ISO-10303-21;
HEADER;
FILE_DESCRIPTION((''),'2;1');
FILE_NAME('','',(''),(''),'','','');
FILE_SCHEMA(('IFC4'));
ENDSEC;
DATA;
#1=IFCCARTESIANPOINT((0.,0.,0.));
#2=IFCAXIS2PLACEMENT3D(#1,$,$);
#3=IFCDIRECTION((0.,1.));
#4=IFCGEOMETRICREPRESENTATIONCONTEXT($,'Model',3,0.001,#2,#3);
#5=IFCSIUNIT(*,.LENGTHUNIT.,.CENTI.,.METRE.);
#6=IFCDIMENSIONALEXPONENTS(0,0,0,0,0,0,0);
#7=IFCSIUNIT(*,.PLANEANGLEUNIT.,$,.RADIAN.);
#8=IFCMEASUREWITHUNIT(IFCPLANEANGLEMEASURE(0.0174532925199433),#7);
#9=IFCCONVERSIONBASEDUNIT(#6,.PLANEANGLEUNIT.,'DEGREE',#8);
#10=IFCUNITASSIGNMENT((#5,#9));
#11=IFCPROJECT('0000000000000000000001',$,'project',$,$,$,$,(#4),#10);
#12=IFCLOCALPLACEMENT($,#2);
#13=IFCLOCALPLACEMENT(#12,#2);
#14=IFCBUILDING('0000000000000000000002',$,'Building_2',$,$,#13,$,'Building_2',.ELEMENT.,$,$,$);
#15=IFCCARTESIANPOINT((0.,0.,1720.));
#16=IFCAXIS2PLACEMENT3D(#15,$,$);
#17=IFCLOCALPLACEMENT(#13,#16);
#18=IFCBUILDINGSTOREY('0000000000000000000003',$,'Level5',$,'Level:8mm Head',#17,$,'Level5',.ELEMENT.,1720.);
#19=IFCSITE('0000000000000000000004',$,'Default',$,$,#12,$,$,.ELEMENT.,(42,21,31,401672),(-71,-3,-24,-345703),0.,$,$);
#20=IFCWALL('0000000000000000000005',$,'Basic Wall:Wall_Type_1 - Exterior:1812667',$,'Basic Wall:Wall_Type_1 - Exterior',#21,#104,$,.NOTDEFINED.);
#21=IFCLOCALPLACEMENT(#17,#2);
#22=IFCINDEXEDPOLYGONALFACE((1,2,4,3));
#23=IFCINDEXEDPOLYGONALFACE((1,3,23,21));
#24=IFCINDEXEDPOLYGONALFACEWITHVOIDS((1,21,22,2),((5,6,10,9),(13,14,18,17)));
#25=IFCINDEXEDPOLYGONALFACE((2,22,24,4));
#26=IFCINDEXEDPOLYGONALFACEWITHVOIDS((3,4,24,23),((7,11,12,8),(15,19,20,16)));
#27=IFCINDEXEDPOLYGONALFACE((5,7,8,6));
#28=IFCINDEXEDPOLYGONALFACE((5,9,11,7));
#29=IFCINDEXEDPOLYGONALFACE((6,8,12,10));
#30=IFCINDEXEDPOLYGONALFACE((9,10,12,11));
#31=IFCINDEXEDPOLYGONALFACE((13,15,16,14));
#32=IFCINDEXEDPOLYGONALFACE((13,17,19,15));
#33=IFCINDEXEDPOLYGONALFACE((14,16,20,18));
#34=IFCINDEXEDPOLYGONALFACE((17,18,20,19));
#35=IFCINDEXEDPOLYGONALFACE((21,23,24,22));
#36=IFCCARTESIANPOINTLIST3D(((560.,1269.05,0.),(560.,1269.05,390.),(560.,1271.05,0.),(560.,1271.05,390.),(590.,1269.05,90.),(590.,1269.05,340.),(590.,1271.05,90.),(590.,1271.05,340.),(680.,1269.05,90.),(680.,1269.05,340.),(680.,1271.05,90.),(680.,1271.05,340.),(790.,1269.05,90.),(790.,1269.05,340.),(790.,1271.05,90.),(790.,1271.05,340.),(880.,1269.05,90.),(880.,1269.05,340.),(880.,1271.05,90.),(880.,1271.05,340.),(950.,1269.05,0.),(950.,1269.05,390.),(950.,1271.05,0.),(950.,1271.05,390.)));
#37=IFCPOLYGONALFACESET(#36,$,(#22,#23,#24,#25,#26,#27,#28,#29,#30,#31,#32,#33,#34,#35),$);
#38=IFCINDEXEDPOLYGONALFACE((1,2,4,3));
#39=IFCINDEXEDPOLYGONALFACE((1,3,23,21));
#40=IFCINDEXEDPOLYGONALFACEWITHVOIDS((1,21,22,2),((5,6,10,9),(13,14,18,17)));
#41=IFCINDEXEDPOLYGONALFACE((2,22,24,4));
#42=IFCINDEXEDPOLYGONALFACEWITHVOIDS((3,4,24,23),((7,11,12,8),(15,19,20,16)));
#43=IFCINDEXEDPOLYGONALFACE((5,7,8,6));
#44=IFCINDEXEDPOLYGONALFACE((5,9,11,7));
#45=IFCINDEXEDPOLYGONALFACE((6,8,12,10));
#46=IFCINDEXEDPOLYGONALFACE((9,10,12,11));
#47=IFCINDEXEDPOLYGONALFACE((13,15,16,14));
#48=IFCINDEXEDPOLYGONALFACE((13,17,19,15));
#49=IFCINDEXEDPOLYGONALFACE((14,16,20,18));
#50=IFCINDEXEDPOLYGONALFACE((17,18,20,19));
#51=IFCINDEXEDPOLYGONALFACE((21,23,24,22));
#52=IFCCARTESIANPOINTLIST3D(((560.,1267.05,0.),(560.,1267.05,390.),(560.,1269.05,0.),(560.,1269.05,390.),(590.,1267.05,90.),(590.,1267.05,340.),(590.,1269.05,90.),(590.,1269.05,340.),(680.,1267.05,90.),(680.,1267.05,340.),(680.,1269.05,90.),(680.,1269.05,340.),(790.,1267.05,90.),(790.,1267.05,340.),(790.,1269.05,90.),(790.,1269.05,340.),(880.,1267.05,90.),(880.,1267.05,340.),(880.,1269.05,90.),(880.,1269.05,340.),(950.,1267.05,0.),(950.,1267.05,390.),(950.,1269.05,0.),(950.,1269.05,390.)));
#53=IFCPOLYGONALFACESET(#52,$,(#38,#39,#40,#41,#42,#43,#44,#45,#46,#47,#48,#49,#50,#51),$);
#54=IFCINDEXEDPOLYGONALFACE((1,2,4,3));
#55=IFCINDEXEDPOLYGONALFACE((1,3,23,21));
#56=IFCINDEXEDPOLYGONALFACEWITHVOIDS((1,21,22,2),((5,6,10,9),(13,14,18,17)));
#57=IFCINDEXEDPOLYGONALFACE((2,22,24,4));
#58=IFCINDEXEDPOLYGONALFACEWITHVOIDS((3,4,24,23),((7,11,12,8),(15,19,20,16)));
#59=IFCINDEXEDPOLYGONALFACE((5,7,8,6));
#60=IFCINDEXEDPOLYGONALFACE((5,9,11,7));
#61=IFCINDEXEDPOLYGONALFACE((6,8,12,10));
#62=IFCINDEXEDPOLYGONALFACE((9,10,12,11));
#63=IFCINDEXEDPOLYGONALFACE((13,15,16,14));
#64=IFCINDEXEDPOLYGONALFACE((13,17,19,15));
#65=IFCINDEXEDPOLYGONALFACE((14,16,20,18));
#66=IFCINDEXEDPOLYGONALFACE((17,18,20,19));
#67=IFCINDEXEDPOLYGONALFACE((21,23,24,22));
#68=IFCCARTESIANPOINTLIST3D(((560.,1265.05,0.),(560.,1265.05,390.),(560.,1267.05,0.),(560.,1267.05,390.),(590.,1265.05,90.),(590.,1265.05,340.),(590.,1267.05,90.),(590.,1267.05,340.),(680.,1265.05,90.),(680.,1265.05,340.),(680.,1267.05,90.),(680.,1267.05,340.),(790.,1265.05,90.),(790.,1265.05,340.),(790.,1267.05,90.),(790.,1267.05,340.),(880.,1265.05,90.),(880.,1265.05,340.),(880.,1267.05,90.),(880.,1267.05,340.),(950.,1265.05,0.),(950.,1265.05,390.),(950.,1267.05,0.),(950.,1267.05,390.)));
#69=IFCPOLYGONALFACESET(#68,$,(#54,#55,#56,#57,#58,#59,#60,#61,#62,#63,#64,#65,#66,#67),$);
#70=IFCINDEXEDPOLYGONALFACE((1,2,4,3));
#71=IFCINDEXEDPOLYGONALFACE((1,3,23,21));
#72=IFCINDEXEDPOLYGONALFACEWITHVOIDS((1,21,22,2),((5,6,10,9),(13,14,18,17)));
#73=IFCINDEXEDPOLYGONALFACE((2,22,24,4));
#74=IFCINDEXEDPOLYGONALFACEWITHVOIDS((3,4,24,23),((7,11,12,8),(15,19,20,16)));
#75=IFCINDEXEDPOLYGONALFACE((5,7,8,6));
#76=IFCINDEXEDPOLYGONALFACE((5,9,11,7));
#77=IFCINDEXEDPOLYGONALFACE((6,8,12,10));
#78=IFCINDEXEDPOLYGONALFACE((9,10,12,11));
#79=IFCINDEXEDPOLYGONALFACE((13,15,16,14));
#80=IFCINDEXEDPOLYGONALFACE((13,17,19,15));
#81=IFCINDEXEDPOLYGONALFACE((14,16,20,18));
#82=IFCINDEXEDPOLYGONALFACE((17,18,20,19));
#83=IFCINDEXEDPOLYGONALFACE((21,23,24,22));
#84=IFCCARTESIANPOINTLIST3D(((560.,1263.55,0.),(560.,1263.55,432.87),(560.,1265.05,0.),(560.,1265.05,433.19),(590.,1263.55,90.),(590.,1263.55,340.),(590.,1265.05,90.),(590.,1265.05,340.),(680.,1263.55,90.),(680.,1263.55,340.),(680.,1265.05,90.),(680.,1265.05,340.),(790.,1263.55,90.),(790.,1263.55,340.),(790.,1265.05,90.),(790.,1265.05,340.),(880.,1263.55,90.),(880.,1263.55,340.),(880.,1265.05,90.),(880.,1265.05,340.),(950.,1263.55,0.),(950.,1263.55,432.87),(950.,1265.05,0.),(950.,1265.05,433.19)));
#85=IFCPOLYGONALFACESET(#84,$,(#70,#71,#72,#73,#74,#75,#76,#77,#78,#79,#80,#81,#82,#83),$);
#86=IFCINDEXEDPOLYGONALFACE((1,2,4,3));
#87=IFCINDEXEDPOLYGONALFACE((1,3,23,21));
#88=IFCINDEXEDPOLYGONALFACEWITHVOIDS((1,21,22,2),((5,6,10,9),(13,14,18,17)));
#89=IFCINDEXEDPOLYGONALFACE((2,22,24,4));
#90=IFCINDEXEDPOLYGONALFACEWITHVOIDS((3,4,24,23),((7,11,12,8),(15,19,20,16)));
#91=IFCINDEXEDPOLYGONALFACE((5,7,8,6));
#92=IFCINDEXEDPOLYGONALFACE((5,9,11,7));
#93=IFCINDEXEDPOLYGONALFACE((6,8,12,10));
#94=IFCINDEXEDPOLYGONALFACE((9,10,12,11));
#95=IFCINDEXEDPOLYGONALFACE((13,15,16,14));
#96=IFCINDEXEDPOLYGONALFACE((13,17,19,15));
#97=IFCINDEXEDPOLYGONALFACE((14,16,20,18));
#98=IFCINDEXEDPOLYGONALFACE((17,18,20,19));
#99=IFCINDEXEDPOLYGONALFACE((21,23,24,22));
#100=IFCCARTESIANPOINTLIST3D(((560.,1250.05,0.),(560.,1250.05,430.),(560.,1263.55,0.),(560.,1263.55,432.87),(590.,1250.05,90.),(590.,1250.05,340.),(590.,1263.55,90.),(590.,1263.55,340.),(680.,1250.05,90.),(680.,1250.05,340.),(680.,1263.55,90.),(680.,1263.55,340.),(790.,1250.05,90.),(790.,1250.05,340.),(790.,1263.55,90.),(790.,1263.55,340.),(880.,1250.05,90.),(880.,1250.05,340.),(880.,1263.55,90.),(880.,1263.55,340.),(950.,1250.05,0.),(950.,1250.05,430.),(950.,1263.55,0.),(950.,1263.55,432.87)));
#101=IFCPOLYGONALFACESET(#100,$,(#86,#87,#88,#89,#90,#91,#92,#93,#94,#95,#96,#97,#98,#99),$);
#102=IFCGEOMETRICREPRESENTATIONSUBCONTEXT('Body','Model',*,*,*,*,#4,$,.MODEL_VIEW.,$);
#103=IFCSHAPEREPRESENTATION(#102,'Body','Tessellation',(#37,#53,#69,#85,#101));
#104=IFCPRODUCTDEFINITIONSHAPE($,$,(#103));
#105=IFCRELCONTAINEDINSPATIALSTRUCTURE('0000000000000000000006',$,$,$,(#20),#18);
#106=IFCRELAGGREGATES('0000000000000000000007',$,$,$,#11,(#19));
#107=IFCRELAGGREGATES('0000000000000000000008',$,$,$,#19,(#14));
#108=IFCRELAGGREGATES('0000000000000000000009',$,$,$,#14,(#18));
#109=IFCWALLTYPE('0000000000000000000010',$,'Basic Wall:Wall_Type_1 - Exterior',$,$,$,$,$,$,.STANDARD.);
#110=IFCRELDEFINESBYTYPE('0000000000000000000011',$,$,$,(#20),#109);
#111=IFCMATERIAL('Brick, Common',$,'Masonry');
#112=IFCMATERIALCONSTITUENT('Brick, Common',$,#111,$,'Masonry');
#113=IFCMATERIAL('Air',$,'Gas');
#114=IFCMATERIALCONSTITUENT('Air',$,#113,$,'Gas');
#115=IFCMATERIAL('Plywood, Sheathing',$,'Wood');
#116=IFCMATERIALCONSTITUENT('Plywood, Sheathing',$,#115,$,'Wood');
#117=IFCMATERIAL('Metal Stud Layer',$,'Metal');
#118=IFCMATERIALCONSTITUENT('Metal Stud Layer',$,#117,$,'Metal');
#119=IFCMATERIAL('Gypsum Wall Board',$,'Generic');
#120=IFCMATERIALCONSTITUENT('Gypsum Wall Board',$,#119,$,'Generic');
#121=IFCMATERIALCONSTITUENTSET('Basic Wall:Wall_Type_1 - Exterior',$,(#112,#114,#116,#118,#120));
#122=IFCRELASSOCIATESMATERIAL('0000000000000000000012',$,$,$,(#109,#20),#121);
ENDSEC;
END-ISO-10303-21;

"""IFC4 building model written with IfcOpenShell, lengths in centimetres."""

from ifc_helpers import new_model, entity, si_unit, converted_unit, direction, frame, origin, place, context, subcontext, project, spatial, indexed_curve, outline, extrude, material, constituent, constituent_set, type_object, element, save


model = new_model("IFC4")

# Units and contexts
model_context = context("Model", 3, precision=0.001, world=origin(), true_north=direction((0.0, 1.0)))
body_context = subcontext(model_context, "Body", "Model", "MODEL_VIEW")
ifc_project = project(units=[si_unit("LENGTHUNIT", "METRE", prefix="CENTI"), converted_unit("PLANEANGLEUNIT", "DEGREE", entity("IfcPlaneAngleMeasure", 0.0174532925199433), si_unit("PLANEANGLEUNIT", "RADIAN"), dimensions=[0, 0, 0, 0, 0, 0, 0])], contexts=[model_context])

# Site, building, storey
site_placement = place(None, origin())
site = spatial("IfcSite", under=ifc_project, at=site_placement, Name="Default", CompositionType="ELEMENT", RefLatitude=(42, 21, 31, 401672), RefLongitude=(-71, -3, -24, -345703), RefElevation=0.0)
building_placement = place(site_placement, origin())
building = spatial("IfcBuilding", under=site, at=building_placement, Name="Building_2", LongName="Building_2", CompositionType="ELEMENT")
storey_placement = place(building_placement, frame((0.0, 0.0, 1720.0)))
storey = spatial("IfcBuildingStorey", under=building, at=storey_placement, Name="Level5", ObjectType="Level:8mm Head", LongName="Level5", CompositionType="ELEMENT", Elevation=1720.0)

# Shared definitions
ifc_material_1 = material(Name="Brick, Common", Category="Masonry")
ifc_constituent_1 = constituent(ifc_material_1, Name="Brick, Common", Category="Masonry")
ifc_material_2 = material(Name="Air", Category="Gas")
ifc_constituent_2 = constituent(ifc_material_2, Name="Air", Category="Gas")
ifc_material_3 = material(Name="Plywood, Sheathing", Category="Wood")
ifc_constituent_3 = constituent(ifc_material_3, Name="Plywood, Sheathing", Category="Wood")
ifc_material_4 = material(Name="Metal Stud Layer", Category="Metal")
ifc_constituent_4 = constituent(ifc_material_4, Name="Metal Stud Layer", Category="Metal")
ifc_material_5 = material(Name="Gypsum Wall Board", Category="Generic")
ifc_constituent_5 = constituent(ifc_material_5, Name="Gypsum Wall Board", Category="Generic")
ifc_constituent_set_1 = constituent_set(constituents=[ifc_constituent_1, ifc_constituent_2, ifc_constituent_3, ifc_constituent_4, ifc_constituent_5], Name="Basic Wall:Wall_Type_1 - Exterior")
wall_type_1 = type_object("IfcWallType", Name="Basic Wall:Wall_Type_1 - Exterior", PredefinedType="STANDARD", material=ifc_constituent_set_1)

# Wall, openings
wall_1_placement = place(storey_placement, frame((950.0, 1260.55, 0.0), z_axis=(0.0, 0.0, 1.0), x_axis=(-1.0, 0.0, 0.0)))
wall_1 = element("IfcWall", 1, at=wall_1_placement, inside=storey, type_object=wall_type_1, material=ifc_constituent_set_1, Name="Basic Wall:Wall_Type_1 - Exterior:1812667", ObjectType="Basic Wall:Wall_Type_1 - Exterior", PredefinedType="NOTDEFINED", context=body_context, shape_type="SweptSolid", body=[
    extrude(outline(indexed_curve([(-195.0, -195.0), (195.0, -195.0), (195.0, 195.0), (-195.0, 195.0), (-195.0, -195.0)], self_intersect=False), holes=[indexed_curve([(145.0, -165.0), (-105.0, -165.0), (-105.0, -75.0), (145.0, -75.0), (145.0, -165.0)], self_intersect=False), indexed_curve([(145.0, 35.0), (-105.0, 35.0), (-105.0, 125.0), (145.0, 125.0), (145.0, 35.0)], self_intersect=False)]), frame((195.0, -8.5, 195.0), z_axis=(0.0, -1.0, 0.0), x_axis=(0.0, 0.0, 1.0)), (0.0, 0.0, 1.0), 2.0),
    extrude(outline(indexed_curve([(-195.0, -195.0), (195.0, -195.0), (195.0, 195.0), (-195.0, 195.0), (-195.0, -195.0)], self_intersect=False), holes=[indexed_curve([(145.0, -165.0), (-105.0, -165.0), (-105.0, -75.0), (145.0, -75.0), (145.0, -165.0)], self_intersect=False), indexed_curve([(145.0, 35.0), (-105.0, 35.0), (-105.0, 125.0), (145.0, 125.0), (145.0, 35.0)], self_intersect=False)]), frame((195.0, -6.5, 195.0), z_axis=(0.0, -1.0, 0.0), x_axis=(0.0, 0.0, 1.0)), (0.0, 0.0, 1.0), 2.0),
    extrude(outline(indexed_curve([(-195.0, -195.0), (195.0, -195.0), (195.0, 195.0), (-195.0, 195.0), (-195.0, -195.0)], self_intersect=False), holes=[indexed_curve([(145.0, -165.0), (-105.0, -165.0), (-105.0, -75.0), (145.0, -75.0), (145.0, -165.0)], self_intersect=False), indexed_curve([(145.0, 35.0), (-105.0, 35.0), (-105.0, 125.0), (145.0, 125.0), (145.0, 35.0)], self_intersect=False)]), frame((195.0, -4.5, 195.0), z_axis=(0.0, -1.0, 0.0), x_axis=(0.0, 0.0, 1.0)), (0.0, 0.0, 1.0), 2.0),
    extrude(outline(indexed_curve([(-154.36, -1.0), (278.51, -1.0), (278.51, 0.5), (-111.49, 0.5), (-136.49, 0.5), (-154.68, 0.5), (-154.36, -1.0)], self_intersect=False)), frame((390.0, -4.0, 278.51), z_axis=(-1.0, 0.0, 0.0), x_axis=(0.0, 0.0, -1.0)), (0.0, 0.0, 1.0), 390.0),
    extrude(outline(indexed_curve([(-6.75, -215.72), (6.75, -215.72), (6.75, 217.15), (-6.75, 214.28), (-6.75, -215.72)], self_intersect=False)), frame((390.0, 3.75, 215.72), z_axis=(-1.0, 0.0, 0.0), x_axis=(0.0, -1.0, 0.0)), (0.0, 0.0, 1.0), 390.0),
])
opening_1_placement = place(storey_placement, frame((950.0, 1260.55, 0.0), z_axis=(0.0, 0.0, 1.0), x_axis=(-1.0, 0.0, 0.0)))
element("IfcOpeningElement", 2, at=opening_1_placement, cuts=wall_1, PredefinedType="OPENING", context=body_context, shape_type="SweptSolid", body=[
    extrude(outline(indexed_curve([(-45.0, -125.0), (45.0, -125.0), (45.0, 125.0), (-45.0, 125.0), (-45.0, -125.0)], self_intersect=False)), frame((315.0, 10.5, 215.0), z_axis=(0.0, -1.0, 0.0), x_axis=(-1.0, 0.0, 0.0)), (0.0, 0.0, 1.0), 13.5),
])
opening_2_placement = place(storey_placement, frame((950.0, 1260.55, 0.0), z_axis=(0.0, 0.0, 1.0), x_axis=(-1.0, 0.0, 0.0)))
element("IfcOpeningElement", 3, at=opening_2_placement, cuts=wall_1, PredefinedType="OPENING", context=body_context, shape_type="SweptSolid", body=[
    extrude(outline(indexed_curve([(-45.0, -125.0), (45.0, -125.0), (45.0, 125.0), (-45.0, 125.0), (-45.0, -125.0)], self_intersect=False)), frame((115.0, 10.5, 215.0), z_axis=(0.0, -1.0, 0.0), x_axis=(-1.0, 0.0, 0.0)), (0.0, 0.0, 1.0), 13.5),
])
opening_3_placement = place(storey_placement, frame((950.0, 1260.55, 0.0), z_axis=(0.0, 0.0, 1.0), x_axis=(-1.0, 0.0, 0.0)))
element("IfcOpeningElement", 4, at=opening_3_placement, cuts=wall_1, PredefinedType="OPENING", context=body_context, shape_type="SweptSolid", body=[
    extrude(outline(indexed_curve([(-45.0, -125.0), (45.0, -125.0), (45.0, 125.0), (-45.0, 125.0), (-45.0, -125.0)], self_intersect=False)), frame((115.0, -3.0, 215.0), z_axis=(0.0, -1.0, 0.0), x_axis=(-1.0, 0.0, 0.0)), (0.0, 0.0, 1.0), 1.5),
])
opening_4_placement = place(storey_placement, frame((950.0, 1260.55, 0.0), z_axis=(0.0, 0.0, 1.0), x_axis=(-1.0, 0.0, 0.0)))
element("IfcOpeningElement", 5, at=opening_4_placement, cuts=wall_1, PredefinedType="OPENING", context=body_context, shape_type="SweptSolid", body=[
    extrude(outline(indexed_curve([(-45.0, -125.0), (45.0, -125.0), (45.0, 125.0), (-45.0, 125.0), (-45.0, -125.0)], self_intersect=False)), frame((315.0, -3.0, 215.0), z_axis=(0.0, -1.0, 0.0), x_axis=(-1.0, 0.0, 0.0)), (0.0, 0.0, 1.0), 1.5),
])
opening_5_placement = place(wall_1_placement, frame((360.0, 10.5, 90.0)))
element("IfcOpeningElement", 6, at=opening_5_placement, cuts=wall_1, PredefinedType="OPENING", context=body_context, shape_type="SweptSolid", body=[
    extrude(outline(indexed_curve([(250.0, 90.0), (0.0, 90.0), (0.0, 0.0), (250.0, 0.0), (250.0, 90.0)], self_intersect=False)), frame((0.0, 0.0, 0.0), z_axis=(0.0, -1.0, 0.0), x_axis=(0.0, 0.0, 1.0)), (0.0, 0.0, 1.0), 21.0),
])
opening_6_placement = place(wall_1_placement, frame((950.0, 1260.55, 0.0), z_axis=(0.0, 0.0, 1.0), x_axis=(-1.0, 0.0, 0.0)))
element("IfcOpeningElement", 7, at=opening_6_placement, cuts=wall_1, PredefinedType="OPENING", context=body_context, shape_type="SweptSolid", body=[
    extrude(outline(indexed_curve([(-45.0, -125.0), (45.0, -125.0), (45.0, 125.0), (-45.0, 125.0), (-45.0, -125.0)], self_intersect=False)), frame((635.0, 1402.45, 215.0), z_axis=(0.0, -1.0, 0.0), x_axis=(-1.0, 0.0, 0.0)), (0.0, 0.0, 1.0), 304.8),
])
opening_7_placement = place(wall_1_placement, frame((160.0, 10.5, 90.0)))
element("IfcOpeningElement", 8, at=opening_7_placement, cuts=wall_1, PredefinedType="OPENING", context=body_context, shape_type="SweptSolid", body=[
    extrude(outline(indexed_curve([(250.0, 90.0), (0.0, 90.0), (0.0, 0.0), (250.0, 0.0), (250.0, 90.0)], self_intersect=False)), frame((0.0, 0.0, 0.0), z_axis=(0.0, -1.0, 0.0), x_axis=(0.0, 0.0, 1.0)), (0.0, 0.0, 1.0), 21.0),
])
opening_8_placement = place(wall_1_placement, frame((950.0, 1260.55, 0.0), z_axis=(0.0, 0.0, 1.0), x_axis=(-1.0, 0.0, 0.0)))
element("IfcOpeningElement", 9, at=opening_8_placement, cuts=wall_1, PredefinedType="OPENING", context=body_context, shape_type="SweptSolid", body=[
    extrude(outline(indexed_curve([(-45.0, -125.0), (45.0, -125.0), (45.0, 125.0), (-45.0, 125.0), (-45.0, -125.0)], self_intersect=False)), frame((835.0, 1402.45, 215.0), z_axis=(0.0, -1.0, 0.0), x_axis=(-1.0, 0.0, 0.0)), (0.0, 0.0, 1.0), 304.8),
])

save(model, "model.ifc")
